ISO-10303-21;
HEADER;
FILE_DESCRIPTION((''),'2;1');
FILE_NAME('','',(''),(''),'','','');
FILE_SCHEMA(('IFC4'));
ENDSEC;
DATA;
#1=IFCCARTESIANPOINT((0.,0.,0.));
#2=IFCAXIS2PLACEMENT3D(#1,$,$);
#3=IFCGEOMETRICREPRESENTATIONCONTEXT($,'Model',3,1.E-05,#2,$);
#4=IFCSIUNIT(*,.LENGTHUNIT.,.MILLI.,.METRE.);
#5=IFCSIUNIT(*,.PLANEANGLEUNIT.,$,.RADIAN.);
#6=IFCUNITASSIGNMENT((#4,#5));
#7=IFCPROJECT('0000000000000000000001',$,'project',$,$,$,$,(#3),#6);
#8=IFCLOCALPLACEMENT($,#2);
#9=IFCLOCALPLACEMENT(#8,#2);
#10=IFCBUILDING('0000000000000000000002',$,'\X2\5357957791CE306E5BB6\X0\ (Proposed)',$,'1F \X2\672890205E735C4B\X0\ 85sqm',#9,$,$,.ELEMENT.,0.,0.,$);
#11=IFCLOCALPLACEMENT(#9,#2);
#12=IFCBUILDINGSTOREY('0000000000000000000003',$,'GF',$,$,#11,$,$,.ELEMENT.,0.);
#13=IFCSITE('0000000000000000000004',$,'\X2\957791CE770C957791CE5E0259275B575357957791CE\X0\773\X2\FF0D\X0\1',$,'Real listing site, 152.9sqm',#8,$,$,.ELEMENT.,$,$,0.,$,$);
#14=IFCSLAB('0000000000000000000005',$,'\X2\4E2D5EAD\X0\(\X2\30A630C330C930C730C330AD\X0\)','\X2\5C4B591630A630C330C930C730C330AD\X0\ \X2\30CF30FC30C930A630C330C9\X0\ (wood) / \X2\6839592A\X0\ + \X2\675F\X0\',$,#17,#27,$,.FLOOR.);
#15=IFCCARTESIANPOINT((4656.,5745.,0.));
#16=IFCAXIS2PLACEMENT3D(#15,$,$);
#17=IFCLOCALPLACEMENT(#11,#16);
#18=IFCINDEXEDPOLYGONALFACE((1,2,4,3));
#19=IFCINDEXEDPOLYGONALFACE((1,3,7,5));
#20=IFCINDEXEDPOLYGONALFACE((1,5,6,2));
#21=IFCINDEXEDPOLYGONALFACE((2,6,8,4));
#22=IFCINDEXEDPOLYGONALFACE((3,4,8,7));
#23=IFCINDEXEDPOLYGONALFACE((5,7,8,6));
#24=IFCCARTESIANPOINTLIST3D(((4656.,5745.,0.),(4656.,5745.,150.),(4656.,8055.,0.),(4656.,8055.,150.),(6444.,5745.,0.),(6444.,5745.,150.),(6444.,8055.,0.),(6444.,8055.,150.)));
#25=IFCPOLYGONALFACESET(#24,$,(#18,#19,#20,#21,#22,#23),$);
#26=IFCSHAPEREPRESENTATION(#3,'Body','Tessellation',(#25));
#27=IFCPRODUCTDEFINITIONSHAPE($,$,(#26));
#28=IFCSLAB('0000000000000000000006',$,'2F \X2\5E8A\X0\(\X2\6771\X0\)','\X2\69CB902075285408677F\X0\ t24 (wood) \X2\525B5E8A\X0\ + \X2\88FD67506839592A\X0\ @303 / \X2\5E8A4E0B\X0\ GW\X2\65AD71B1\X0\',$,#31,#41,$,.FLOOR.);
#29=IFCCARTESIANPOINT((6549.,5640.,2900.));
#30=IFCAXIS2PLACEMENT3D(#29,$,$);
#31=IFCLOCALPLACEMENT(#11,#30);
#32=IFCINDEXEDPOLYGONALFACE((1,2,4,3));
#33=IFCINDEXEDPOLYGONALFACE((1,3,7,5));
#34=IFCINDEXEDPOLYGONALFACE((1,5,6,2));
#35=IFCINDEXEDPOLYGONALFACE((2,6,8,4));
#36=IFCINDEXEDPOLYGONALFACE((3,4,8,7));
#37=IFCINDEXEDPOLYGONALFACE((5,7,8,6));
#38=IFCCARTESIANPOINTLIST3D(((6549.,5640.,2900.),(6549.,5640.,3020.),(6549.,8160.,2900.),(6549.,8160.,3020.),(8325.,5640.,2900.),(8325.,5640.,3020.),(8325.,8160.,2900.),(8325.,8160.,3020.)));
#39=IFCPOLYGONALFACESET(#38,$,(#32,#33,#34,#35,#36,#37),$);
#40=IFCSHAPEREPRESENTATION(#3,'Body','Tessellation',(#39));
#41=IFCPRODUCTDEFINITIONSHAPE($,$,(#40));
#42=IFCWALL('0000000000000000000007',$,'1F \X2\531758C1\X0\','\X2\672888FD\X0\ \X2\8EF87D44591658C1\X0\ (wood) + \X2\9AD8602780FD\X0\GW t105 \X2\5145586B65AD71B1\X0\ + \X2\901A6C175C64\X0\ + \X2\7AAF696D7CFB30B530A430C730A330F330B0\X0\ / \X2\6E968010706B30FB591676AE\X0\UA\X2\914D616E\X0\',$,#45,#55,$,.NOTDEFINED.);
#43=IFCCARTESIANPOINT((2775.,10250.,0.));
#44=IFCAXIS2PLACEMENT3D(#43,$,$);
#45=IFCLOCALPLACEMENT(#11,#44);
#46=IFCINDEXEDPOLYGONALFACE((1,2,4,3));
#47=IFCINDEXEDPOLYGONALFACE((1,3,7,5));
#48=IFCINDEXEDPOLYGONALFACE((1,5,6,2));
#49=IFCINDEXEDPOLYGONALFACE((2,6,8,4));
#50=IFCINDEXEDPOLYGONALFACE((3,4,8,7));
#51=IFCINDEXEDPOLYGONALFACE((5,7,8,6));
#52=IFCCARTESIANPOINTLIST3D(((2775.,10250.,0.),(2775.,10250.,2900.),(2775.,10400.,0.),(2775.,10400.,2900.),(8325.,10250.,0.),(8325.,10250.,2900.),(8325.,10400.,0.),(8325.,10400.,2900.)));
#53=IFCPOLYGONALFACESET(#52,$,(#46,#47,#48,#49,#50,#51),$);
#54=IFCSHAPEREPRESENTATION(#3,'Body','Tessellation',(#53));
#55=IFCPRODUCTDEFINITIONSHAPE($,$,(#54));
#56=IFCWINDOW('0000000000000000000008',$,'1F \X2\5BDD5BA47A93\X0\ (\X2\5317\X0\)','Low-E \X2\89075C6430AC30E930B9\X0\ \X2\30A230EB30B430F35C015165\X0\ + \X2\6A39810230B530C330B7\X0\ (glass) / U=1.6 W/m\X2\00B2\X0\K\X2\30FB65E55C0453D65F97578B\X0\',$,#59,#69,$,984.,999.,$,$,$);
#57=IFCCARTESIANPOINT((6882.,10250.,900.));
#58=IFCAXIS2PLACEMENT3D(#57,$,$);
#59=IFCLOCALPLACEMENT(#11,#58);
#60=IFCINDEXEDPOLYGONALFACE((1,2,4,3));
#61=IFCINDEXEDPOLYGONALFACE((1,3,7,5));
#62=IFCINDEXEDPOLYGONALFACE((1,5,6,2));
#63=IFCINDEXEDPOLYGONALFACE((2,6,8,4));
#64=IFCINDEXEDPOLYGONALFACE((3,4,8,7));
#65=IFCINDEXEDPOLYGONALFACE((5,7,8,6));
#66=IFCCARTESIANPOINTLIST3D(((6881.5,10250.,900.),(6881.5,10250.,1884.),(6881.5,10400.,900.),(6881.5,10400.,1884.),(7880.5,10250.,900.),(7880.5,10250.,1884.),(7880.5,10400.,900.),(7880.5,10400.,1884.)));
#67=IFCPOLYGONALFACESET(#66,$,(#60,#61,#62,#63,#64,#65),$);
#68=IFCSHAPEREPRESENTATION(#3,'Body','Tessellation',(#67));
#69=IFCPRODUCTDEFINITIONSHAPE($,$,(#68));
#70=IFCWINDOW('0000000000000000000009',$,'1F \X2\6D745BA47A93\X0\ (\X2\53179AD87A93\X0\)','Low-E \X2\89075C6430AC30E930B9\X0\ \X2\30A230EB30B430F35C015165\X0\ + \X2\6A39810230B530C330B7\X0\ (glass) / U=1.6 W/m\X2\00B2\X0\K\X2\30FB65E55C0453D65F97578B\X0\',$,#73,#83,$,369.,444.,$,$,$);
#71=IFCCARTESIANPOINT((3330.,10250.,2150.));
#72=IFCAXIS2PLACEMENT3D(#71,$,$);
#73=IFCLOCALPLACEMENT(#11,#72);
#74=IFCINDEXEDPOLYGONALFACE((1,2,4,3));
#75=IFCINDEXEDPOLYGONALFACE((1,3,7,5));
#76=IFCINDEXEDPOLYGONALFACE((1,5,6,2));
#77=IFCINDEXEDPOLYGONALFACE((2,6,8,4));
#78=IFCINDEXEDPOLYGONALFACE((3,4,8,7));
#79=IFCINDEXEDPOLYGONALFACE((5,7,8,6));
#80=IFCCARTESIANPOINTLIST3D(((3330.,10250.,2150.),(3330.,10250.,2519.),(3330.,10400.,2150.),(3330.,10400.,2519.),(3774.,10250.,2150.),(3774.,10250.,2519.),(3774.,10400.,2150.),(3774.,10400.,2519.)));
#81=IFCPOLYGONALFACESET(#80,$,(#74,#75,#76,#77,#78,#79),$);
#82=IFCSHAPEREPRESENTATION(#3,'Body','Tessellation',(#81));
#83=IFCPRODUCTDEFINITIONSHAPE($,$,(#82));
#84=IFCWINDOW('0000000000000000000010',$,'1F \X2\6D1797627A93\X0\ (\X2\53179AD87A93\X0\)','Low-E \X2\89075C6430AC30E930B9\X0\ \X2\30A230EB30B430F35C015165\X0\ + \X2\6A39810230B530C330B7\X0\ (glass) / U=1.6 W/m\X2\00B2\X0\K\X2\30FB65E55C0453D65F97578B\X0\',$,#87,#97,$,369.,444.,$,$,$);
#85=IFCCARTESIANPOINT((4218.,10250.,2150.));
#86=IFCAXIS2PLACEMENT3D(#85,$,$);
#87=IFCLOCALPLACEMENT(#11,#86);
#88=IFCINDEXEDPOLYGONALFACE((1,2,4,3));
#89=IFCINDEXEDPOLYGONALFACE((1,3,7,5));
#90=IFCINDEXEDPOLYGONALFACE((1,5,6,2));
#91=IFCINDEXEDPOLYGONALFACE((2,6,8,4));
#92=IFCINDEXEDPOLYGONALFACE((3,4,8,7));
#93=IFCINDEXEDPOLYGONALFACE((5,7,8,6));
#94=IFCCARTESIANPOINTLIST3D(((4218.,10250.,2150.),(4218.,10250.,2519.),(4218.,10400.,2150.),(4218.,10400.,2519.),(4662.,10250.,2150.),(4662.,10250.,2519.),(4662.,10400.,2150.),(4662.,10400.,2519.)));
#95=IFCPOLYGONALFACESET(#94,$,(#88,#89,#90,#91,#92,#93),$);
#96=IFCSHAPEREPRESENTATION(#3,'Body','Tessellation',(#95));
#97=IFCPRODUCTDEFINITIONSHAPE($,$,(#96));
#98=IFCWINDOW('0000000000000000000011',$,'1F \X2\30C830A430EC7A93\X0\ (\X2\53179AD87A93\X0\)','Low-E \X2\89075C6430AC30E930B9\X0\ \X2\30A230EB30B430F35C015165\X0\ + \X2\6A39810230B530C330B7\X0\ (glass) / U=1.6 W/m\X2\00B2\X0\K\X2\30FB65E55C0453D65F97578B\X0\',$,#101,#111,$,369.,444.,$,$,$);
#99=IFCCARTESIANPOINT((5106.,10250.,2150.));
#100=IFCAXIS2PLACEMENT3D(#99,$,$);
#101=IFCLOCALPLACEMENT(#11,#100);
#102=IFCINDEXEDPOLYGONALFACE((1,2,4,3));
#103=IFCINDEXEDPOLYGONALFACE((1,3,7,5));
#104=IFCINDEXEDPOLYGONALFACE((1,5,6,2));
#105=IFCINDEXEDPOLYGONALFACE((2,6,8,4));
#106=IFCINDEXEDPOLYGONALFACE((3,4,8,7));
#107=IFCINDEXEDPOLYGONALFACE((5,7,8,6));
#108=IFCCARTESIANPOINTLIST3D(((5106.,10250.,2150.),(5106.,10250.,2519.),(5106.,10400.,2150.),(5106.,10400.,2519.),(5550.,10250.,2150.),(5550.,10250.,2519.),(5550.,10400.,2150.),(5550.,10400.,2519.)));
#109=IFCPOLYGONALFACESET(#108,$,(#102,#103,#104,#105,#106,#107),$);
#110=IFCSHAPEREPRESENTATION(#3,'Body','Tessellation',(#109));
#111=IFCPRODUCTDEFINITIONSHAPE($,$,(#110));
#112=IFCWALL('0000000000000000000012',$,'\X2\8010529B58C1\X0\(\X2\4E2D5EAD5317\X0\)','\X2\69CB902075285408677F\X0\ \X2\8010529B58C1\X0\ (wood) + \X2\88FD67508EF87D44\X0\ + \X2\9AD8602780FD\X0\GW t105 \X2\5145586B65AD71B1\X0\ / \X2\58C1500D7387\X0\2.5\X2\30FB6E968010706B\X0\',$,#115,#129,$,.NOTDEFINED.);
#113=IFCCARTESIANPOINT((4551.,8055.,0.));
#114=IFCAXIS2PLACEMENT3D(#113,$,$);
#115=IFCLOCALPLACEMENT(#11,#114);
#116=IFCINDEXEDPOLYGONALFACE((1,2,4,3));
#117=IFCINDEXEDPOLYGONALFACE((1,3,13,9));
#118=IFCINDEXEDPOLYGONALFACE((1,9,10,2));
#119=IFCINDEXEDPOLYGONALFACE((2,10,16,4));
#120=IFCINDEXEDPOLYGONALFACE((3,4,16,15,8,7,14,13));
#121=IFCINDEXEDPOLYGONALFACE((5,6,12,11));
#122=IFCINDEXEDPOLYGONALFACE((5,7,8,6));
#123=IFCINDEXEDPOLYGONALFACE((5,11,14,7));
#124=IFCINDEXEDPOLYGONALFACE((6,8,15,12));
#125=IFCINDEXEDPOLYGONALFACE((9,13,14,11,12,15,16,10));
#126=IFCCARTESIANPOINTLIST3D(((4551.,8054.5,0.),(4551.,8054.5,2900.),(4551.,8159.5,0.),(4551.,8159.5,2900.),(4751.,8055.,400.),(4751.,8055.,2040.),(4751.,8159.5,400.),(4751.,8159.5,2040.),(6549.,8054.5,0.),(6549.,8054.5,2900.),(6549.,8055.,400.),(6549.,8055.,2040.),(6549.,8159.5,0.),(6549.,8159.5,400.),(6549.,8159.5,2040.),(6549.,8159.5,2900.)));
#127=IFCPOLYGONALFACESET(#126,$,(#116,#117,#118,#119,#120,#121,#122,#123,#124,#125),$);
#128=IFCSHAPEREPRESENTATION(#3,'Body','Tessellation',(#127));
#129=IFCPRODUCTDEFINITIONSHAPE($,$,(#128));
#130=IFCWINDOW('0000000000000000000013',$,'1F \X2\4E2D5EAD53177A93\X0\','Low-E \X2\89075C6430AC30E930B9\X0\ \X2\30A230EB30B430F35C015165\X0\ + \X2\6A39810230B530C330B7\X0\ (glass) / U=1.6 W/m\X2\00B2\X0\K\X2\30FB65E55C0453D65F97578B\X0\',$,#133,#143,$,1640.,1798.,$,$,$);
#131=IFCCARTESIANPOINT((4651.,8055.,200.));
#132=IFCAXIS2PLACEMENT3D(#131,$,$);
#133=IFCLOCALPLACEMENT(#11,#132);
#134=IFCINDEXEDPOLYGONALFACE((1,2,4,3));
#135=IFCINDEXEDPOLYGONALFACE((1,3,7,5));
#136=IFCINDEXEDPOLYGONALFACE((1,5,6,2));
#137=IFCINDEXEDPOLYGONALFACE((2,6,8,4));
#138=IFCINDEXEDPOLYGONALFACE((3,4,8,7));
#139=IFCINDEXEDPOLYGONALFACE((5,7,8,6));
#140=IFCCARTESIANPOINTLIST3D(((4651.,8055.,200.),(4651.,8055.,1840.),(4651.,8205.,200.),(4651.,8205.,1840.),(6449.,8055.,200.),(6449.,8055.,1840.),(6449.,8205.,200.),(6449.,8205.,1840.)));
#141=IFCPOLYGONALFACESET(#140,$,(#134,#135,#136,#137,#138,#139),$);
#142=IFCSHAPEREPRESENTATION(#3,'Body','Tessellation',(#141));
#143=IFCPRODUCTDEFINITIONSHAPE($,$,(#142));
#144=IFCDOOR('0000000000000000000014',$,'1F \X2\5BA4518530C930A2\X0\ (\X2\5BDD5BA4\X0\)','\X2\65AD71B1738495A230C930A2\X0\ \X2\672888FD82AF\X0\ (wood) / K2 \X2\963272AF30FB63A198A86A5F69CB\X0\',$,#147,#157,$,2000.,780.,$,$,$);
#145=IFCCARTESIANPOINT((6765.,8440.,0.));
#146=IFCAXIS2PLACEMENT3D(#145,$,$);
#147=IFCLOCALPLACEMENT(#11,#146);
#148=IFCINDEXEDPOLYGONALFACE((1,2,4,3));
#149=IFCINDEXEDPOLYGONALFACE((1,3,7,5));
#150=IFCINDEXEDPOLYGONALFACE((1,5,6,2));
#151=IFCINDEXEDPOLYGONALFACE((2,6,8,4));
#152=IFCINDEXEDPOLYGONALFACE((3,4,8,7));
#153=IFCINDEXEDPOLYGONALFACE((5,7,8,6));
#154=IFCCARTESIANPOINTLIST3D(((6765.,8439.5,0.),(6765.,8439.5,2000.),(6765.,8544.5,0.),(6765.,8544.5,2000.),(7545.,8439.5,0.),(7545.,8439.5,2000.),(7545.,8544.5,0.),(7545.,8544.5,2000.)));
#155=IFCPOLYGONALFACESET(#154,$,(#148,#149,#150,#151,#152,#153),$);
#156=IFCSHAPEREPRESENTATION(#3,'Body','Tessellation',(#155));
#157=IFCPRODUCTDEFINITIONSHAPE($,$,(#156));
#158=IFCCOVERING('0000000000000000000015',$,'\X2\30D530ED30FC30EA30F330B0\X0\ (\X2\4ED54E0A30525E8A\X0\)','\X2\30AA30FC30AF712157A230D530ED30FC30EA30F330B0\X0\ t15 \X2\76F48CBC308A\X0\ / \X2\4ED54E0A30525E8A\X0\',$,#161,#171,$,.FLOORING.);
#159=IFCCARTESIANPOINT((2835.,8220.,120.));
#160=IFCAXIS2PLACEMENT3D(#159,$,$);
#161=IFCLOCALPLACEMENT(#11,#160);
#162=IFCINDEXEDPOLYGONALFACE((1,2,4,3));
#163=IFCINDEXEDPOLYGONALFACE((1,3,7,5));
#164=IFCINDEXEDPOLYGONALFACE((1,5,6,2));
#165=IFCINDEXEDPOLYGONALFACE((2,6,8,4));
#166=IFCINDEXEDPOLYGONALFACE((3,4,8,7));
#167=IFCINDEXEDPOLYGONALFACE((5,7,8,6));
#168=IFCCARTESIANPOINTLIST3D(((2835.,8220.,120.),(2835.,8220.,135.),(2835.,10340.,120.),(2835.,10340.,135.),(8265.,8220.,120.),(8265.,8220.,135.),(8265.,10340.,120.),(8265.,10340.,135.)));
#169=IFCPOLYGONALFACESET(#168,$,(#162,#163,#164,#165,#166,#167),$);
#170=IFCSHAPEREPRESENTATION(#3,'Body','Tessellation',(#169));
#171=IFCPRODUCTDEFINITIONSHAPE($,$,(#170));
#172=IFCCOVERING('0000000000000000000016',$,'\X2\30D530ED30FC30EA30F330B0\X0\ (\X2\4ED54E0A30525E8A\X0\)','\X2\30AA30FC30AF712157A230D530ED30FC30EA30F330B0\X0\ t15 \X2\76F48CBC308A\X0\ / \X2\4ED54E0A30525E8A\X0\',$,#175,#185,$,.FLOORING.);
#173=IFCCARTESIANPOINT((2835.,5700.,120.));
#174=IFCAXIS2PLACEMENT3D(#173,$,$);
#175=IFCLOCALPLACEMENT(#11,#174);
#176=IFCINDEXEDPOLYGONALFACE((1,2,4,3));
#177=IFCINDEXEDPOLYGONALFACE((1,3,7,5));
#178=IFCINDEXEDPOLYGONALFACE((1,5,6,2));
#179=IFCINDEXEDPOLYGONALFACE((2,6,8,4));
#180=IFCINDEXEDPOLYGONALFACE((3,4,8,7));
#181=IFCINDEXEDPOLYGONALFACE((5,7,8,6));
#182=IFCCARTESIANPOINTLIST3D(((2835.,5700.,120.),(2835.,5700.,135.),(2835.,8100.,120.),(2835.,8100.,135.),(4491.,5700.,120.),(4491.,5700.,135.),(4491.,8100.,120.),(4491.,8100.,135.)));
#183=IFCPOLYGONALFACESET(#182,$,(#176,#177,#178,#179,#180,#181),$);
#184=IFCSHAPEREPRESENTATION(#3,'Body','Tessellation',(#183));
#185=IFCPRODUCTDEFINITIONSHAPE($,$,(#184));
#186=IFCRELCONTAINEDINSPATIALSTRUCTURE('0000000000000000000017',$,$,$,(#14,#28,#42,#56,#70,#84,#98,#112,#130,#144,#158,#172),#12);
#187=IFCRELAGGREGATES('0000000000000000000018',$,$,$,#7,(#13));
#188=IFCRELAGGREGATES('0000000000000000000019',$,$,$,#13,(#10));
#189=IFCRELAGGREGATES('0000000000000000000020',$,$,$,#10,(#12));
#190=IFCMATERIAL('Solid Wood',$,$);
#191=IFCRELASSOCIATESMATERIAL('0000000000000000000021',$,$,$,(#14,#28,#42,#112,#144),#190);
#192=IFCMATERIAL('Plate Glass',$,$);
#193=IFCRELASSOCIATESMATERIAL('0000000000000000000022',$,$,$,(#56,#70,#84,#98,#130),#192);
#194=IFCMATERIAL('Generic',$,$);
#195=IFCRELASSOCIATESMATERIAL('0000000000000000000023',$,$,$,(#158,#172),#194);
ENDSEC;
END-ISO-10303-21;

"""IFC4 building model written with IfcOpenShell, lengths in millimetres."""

from ifc_helpers import new_model, si_unit, frame, frame_2d, origin, place, context, project, spatial, rectangle, extrude, material, element, fill, save


model = new_model("IFC4")

# Units and contexts
model_context = context("Model", 3, precision=1e-05, world=origin())
ifc_project = project(units=[si_unit("LENGTHUNIT", "METRE", prefix="MILLI"), si_unit("PLANEANGLEUNIT", "RADIAN")], contexts=[model_context])

# Site, building, storey
site_placement = place(None, origin())
site = spatial("IfcSite", under=ifc_project, at=site_placement, Name="長野県長野市大字南長野773－1", ObjectType="Real listing site, 152.9sqm", CompositionType="ELEMENT", RefElevation=0.0)
building_placement = place(site_placement, origin())
building = spatial("IfcBuilding", under=site, at=building_placement, Name="南長野の家 (Proposed)", ObjectType="1F 木造平屋 85sqm", CompositionType="ELEMENT", ElevationOfRefHeight=0.0, ElevationOfTerrain=0.0)
storey_placement = place(building_placement, origin())
storey = spatial("IfcBuildingStorey", under=building, at=storey_placement, Name="GF", CompositionType="ELEMENT", Elevation=0.0)

# Slabs
ifc_material_1 = material(Name="Solid Wood")
slab_1_placement = place(storey_placement, frame((4656.0, 5745.0, 0.0)))
element("IfcSlab", 1, at=slab_1_placement, inside=storey, material=ifc_material_1, Name="中庭(ウッドデッキ)", Description="屋外ウッドデッキ ハードウッド (wood) / 根太 + 束", PredefinedType="FLOOR", context=model_context, shape_type="SweptSolid", body=[
    extrude(rectangle(XDim=1788.0, YDim=2310.0, at=frame_2d((894.0, 1155.0))), frame((4656.0, 5745.0, 0.0)), (0.0, 0.0, 1.0), 150.0),
])
slab_2_placement = place(storey_placement, frame((6549.0, 5640.0, 2900.0)))
element("IfcSlab", 2, at=slab_2_placement, inside=storey, material=ifc_material_1, Name="2F 床(東)", Description="構造用合板 t24 (wood) 剛床 + 製材根太 @303 / 床下 GW断熱", PredefinedType="FLOOR", context=model_context, shape_type="SweptSolid", body=[
    extrude(rectangle(XDim=1776.0, YDim=2520.0, at=frame_2d((888.0, 1260.0))), frame((6549.0, 5640.0, 2900.0)), (0.0, 0.0, 1.0), 120.0),
])

# Wall, openings, windows
wall_1_placement = place(storey_placement, frame((2775.0, 10250.0, 0.0)))
wall_1 = element("IfcWall", 3, at=wall_1_placement, inside=storey, material=ifc_material_1, Name="1F 北壁", Description="木製 軸組外壁 (wood) + 高性能GW t105 充填断熱 + 通気層 + 窯業系サイディング / 準耐火・外皮UA配慮", PredefinedType="NOTDEFINED", context=model_context, shape_type="SweptSolid", body=[
    extrude(rectangle(XDim=5550.0, YDim=150.0, at=frame_2d((2775.0, 75.0))), frame((2775.0, 10250.0, 0.0)), (0.0, 0.0, 1.0), 2900.0),
])
opening_1_placement = place(storey_placement, frame((6882.0, 10250.0, 900.0)))
opening_1 = element("IfcOpeningElement", 4, at=opening_1_placement, cuts=wall_1, PredefinedType="NOTDEFINED", context=model_context, shape_type="SweptSolid", body=[
    extrude(rectangle(XDim=999.0, YDim=150.0, at=frame_2d((499.0, 75.0))), frame((6882.0, 10250.0, 900.0)), (0.0, 0.0, 1.0), 984.0),
])
opening_2_placement = place(storey_placement, frame((3330.0, 10250.0, 2150.0)))
opening_2 = element("IfcOpeningElement", 5, at=opening_2_placement, cuts=wall_1, PredefinedType="NOTDEFINED", context=model_context, shape_type="SweptSolid", body=[
    extrude(rectangle(XDim=444.0, YDim=150.0, at=frame_2d((222.0, 75.0))), frame((3330.0, 10250.0, 2150.0)), (0.0, 0.0, 1.0), 369.0),
])
opening_3_placement = place(storey_placement, frame((4218.0, 10250.0, 2150.0)))
opening_3 = element("IfcOpeningElement", 6, at=opening_3_placement, cuts=wall_1, PredefinedType="NOTDEFINED", context=model_context, shape_type="SweptSolid", body=[
    extrude(rectangle(XDim=444.0, YDim=150.0, at=frame_2d((222.0, 75.0))), frame((4218.0, 10250.0, 2150.0)), (0.0, 0.0, 1.0), 369.0),
])
opening_4_placement = place(storey_placement, frame((5106.0, 10250.0, 2150.0)))
opening_4 = element("IfcOpeningElement", 7, at=opening_4_placement, cuts=wall_1, PredefinedType="NOTDEFINED", context=model_context, shape_type="SweptSolid", body=[
    extrude(rectangle(XDim=444.0, YDim=150.0, at=frame_2d((222.0, 75.0))), frame((5106.0, 10250.0, 2150.0)), (0.0, 0.0, 1.0), 369.0),
])
ifc_material_2 = material(Name="Plate Glass")
window_1_placement = place(storey_placement, frame((6882.0, 10250.0, 900.0)))
window_1 = element("IfcWindow", 8, at=window_1_placement, inside=storey, material=ifc_material_2, Name="1F 寝室窓 (北)", Description="Low-E 複層ガラス アルゴン封入 + 樹脂サッシ (glass) / U=1.6 W/m²K・日射取得型", OverallHeight=984.0, OverallWidth=999.0, context=model_context, shape_type="SweptSolid", body=[
    extrude(rectangle(XDim=999.0, YDim=150.0, at=frame_2d((499.0, 75.0))), frame((6882.0, 10250.0, 900.0)), (0.0, 0.0, 1.0), 984.0),
])
fill(opening_1, window_1)
window_2_placement = place(storey_placement, frame((3330.0, 10250.0, 2150.0)))
window_2 = element("IfcWindow", 9, at=window_2_placement, inside=storey, material=ifc_material_2, Name="1F 浴室窓 (北高窓)", Description="Low-E 複層ガラス アルゴン封入 + 樹脂サッシ (glass) / U=1.6 W/m²K・日射取得型", OverallHeight=369.0, OverallWidth=444.0, context=model_context, shape_type="SweptSolid", body=[
    extrude(rectangle(XDim=444.0, YDim=150.0, at=frame_2d((222.0, 75.0))), frame((3330.0, 10250.0, 2150.0)), (0.0, 0.0, 1.0), 369.0),
])
fill(opening_2, window_2)
window_3_placement = place(storey_placement, frame((4218.0, 10250.0, 2150.0)))
window_3 = element("IfcWindow", 10, at=window_3_placement, inside=storey, material=ifc_material_2, Name="1F 洗面窓 (北高窓)", Description="Low-E 複層ガラス アルゴン封入 + 樹脂サッシ (glass) / U=1.6 W/m²K・日射取得型", OverallHeight=369.0, OverallWidth=444.0, context=model_context, shape_type="SweptSolid", body=[
    extrude(rectangle(XDim=444.0, YDim=150.0, at=frame_2d((222.0, 75.0))), frame((4218.0, 10250.0, 2150.0)), (0.0, 0.0, 1.0), 369.0),
])
fill(opening_3, window_3)
window_4_placement = place(storey_placement, frame((5106.0, 10250.0, 2150.0)))
window_4 = element("IfcWindow", 11, at=window_4_placement, inside=storey, material=ifc_material_2, Name="1F トイレ窓 (北高窓)", Description="Low-E 複層ガラス アルゴン封入 + 樹脂サッシ (glass) / U=1.6 W/m²K・日射取得型", OverallHeight=369.0, OverallWidth=444.0, context=model_context, shape_type="SweptSolid", body=[
    extrude(rectangle(XDim=444.0, YDim=150.0, at=frame_2d((222.0, 75.0))), frame((5106.0, 10250.0, 2150.0)), (0.0, 0.0, 1.0), 369.0),
])
fill(opening_4, window_4)

# Wall, opening, window
wall_2_placement = place(storey_placement, frame((4551.0, 8055.0, 0.0)))
wall_2 = element("IfcWall", 12, at=wall_2_placement, inside=storey, material=ifc_material_1, Name="耐力壁(中庭北)", Description="構造用合板 耐力壁 (wood) + 製材軸組 + 高性能GW t105 充填断熱 / 壁倍率2.5・準耐火", PredefinedType="NOTDEFINED", context=model_context, shape_type="SweptSolid", body=[
    extrude(rectangle(XDim=1998.0, YDim=105.0, at=frame_2d((999.0, 52.0))), frame((4551.0, 8055.0, 0.0)), (0.0, 0.0, 1.0), 2900.0),
])
opening_5_placement = place(storey_placement, frame((4651.0, 8055.0, 200.0)))
opening_5 = element("IfcOpeningElement", 13, at=opening_5_placement, cuts=wall_2, PredefinedType="NOTDEFINED", context=model_context, shape_type="SweptSolid", body=[
    extrude(rectangle(XDim=1798.0, YDim=150.0, at=frame_2d((899.0, 75.0))), frame((4651.0, 8055.0, 200.0)), (0.0, 0.0, 1.0), 1640.0),
])
window_5_placement = place(storey_placement, frame((4651.0, 8055.0, 200.0)))
window_5 = element("IfcWindow", 14, at=window_5_placement, inside=storey, material=ifc_material_2, Name="1F 中庭北窓", Description="Low-E 複層ガラス アルゴン封入 + 樹脂サッシ (glass) / U=1.6 W/m²K・日射取得型", OverallHeight=1640.0, OverallWidth=1798.0, context=model_context, shape_type="SweptSolid", body=[
    extrude(rectangle(XDim=1798.0, YDim=150.0, at=frame_2d((899.0, 75.0))), frame((4651.0, 8055.0, 200.0)), (0.0, 0.0, 1.0), 1640.0),
])
fill(opening_5, window_5)

# Door
door_1_placement = place(storey_placement, frame((6765.0, 8440.0, 0.0)))
element("IfcDoor", 15, at=door_1_placement, inside=storey, material=ifc_material_1, Name="1F 室内ドア (寝室)", Description="断熱玄関ドア 木製芯 (wood) / K2 防犯・採風機構", OverallHeight=2000.0, OverallWidth=780.0, context=model_context, shape_type="SweptSolid", body=[
    extrude(rectangle(XDim=780.0, YDim=105.0, at=frame_2d((390.0, 52.0))), frame((6765.0, 8440.0, 0.0)), (0.0, 0.0, 1.0), 2000.0),
])

# Coverings
ifc_material_3 = material(Name="Generic")
covering_1_placement = place(storey_placement, frame((2835.0, 8220.0, 120.0)))
element("IfcCovering", 16, at=covering_1_placement, inside=storey, material=ifc_material_3, Name="フローリング (仕上げ床)", Description="オーク無垢フローリング t15 直貼り / 仕上げ床", PredefinedType="FLOORING", context=model_context, shape_type="SweptSolid", body=[
    extrude(rectangle(XDim=5430.0, YDim=2120.0, at=frame_2d((2715.0, 1060.0))), frame((2835.0, 8220.0, 120.0)), (0.0, 0.0, 1.0), 15.0),
])
covering_2_placement = place(storey_placement, frame((2835.0, 5700.0, 120.0)))
element("IfcCovering", 17, at=covering_2_placement, inside=storey, material=ifc_material_3, Name="フローリング (仕上げ床)", Description="オーク無垢フローリング t15 直貼り / 仕上げ床", PredefinedType="FLOORING", context=model_context, shape_type="SweptSolid", body=[
    extrude(rectangle(XDim=1656.0, YDim=2400.0, at=frame_2d((828.0, 1200.0))), frame((2835.0, 5700.0, 120.0)), (0.0, 0.0, 1.0), 15.0),
])

save(model, "model.ifc")
